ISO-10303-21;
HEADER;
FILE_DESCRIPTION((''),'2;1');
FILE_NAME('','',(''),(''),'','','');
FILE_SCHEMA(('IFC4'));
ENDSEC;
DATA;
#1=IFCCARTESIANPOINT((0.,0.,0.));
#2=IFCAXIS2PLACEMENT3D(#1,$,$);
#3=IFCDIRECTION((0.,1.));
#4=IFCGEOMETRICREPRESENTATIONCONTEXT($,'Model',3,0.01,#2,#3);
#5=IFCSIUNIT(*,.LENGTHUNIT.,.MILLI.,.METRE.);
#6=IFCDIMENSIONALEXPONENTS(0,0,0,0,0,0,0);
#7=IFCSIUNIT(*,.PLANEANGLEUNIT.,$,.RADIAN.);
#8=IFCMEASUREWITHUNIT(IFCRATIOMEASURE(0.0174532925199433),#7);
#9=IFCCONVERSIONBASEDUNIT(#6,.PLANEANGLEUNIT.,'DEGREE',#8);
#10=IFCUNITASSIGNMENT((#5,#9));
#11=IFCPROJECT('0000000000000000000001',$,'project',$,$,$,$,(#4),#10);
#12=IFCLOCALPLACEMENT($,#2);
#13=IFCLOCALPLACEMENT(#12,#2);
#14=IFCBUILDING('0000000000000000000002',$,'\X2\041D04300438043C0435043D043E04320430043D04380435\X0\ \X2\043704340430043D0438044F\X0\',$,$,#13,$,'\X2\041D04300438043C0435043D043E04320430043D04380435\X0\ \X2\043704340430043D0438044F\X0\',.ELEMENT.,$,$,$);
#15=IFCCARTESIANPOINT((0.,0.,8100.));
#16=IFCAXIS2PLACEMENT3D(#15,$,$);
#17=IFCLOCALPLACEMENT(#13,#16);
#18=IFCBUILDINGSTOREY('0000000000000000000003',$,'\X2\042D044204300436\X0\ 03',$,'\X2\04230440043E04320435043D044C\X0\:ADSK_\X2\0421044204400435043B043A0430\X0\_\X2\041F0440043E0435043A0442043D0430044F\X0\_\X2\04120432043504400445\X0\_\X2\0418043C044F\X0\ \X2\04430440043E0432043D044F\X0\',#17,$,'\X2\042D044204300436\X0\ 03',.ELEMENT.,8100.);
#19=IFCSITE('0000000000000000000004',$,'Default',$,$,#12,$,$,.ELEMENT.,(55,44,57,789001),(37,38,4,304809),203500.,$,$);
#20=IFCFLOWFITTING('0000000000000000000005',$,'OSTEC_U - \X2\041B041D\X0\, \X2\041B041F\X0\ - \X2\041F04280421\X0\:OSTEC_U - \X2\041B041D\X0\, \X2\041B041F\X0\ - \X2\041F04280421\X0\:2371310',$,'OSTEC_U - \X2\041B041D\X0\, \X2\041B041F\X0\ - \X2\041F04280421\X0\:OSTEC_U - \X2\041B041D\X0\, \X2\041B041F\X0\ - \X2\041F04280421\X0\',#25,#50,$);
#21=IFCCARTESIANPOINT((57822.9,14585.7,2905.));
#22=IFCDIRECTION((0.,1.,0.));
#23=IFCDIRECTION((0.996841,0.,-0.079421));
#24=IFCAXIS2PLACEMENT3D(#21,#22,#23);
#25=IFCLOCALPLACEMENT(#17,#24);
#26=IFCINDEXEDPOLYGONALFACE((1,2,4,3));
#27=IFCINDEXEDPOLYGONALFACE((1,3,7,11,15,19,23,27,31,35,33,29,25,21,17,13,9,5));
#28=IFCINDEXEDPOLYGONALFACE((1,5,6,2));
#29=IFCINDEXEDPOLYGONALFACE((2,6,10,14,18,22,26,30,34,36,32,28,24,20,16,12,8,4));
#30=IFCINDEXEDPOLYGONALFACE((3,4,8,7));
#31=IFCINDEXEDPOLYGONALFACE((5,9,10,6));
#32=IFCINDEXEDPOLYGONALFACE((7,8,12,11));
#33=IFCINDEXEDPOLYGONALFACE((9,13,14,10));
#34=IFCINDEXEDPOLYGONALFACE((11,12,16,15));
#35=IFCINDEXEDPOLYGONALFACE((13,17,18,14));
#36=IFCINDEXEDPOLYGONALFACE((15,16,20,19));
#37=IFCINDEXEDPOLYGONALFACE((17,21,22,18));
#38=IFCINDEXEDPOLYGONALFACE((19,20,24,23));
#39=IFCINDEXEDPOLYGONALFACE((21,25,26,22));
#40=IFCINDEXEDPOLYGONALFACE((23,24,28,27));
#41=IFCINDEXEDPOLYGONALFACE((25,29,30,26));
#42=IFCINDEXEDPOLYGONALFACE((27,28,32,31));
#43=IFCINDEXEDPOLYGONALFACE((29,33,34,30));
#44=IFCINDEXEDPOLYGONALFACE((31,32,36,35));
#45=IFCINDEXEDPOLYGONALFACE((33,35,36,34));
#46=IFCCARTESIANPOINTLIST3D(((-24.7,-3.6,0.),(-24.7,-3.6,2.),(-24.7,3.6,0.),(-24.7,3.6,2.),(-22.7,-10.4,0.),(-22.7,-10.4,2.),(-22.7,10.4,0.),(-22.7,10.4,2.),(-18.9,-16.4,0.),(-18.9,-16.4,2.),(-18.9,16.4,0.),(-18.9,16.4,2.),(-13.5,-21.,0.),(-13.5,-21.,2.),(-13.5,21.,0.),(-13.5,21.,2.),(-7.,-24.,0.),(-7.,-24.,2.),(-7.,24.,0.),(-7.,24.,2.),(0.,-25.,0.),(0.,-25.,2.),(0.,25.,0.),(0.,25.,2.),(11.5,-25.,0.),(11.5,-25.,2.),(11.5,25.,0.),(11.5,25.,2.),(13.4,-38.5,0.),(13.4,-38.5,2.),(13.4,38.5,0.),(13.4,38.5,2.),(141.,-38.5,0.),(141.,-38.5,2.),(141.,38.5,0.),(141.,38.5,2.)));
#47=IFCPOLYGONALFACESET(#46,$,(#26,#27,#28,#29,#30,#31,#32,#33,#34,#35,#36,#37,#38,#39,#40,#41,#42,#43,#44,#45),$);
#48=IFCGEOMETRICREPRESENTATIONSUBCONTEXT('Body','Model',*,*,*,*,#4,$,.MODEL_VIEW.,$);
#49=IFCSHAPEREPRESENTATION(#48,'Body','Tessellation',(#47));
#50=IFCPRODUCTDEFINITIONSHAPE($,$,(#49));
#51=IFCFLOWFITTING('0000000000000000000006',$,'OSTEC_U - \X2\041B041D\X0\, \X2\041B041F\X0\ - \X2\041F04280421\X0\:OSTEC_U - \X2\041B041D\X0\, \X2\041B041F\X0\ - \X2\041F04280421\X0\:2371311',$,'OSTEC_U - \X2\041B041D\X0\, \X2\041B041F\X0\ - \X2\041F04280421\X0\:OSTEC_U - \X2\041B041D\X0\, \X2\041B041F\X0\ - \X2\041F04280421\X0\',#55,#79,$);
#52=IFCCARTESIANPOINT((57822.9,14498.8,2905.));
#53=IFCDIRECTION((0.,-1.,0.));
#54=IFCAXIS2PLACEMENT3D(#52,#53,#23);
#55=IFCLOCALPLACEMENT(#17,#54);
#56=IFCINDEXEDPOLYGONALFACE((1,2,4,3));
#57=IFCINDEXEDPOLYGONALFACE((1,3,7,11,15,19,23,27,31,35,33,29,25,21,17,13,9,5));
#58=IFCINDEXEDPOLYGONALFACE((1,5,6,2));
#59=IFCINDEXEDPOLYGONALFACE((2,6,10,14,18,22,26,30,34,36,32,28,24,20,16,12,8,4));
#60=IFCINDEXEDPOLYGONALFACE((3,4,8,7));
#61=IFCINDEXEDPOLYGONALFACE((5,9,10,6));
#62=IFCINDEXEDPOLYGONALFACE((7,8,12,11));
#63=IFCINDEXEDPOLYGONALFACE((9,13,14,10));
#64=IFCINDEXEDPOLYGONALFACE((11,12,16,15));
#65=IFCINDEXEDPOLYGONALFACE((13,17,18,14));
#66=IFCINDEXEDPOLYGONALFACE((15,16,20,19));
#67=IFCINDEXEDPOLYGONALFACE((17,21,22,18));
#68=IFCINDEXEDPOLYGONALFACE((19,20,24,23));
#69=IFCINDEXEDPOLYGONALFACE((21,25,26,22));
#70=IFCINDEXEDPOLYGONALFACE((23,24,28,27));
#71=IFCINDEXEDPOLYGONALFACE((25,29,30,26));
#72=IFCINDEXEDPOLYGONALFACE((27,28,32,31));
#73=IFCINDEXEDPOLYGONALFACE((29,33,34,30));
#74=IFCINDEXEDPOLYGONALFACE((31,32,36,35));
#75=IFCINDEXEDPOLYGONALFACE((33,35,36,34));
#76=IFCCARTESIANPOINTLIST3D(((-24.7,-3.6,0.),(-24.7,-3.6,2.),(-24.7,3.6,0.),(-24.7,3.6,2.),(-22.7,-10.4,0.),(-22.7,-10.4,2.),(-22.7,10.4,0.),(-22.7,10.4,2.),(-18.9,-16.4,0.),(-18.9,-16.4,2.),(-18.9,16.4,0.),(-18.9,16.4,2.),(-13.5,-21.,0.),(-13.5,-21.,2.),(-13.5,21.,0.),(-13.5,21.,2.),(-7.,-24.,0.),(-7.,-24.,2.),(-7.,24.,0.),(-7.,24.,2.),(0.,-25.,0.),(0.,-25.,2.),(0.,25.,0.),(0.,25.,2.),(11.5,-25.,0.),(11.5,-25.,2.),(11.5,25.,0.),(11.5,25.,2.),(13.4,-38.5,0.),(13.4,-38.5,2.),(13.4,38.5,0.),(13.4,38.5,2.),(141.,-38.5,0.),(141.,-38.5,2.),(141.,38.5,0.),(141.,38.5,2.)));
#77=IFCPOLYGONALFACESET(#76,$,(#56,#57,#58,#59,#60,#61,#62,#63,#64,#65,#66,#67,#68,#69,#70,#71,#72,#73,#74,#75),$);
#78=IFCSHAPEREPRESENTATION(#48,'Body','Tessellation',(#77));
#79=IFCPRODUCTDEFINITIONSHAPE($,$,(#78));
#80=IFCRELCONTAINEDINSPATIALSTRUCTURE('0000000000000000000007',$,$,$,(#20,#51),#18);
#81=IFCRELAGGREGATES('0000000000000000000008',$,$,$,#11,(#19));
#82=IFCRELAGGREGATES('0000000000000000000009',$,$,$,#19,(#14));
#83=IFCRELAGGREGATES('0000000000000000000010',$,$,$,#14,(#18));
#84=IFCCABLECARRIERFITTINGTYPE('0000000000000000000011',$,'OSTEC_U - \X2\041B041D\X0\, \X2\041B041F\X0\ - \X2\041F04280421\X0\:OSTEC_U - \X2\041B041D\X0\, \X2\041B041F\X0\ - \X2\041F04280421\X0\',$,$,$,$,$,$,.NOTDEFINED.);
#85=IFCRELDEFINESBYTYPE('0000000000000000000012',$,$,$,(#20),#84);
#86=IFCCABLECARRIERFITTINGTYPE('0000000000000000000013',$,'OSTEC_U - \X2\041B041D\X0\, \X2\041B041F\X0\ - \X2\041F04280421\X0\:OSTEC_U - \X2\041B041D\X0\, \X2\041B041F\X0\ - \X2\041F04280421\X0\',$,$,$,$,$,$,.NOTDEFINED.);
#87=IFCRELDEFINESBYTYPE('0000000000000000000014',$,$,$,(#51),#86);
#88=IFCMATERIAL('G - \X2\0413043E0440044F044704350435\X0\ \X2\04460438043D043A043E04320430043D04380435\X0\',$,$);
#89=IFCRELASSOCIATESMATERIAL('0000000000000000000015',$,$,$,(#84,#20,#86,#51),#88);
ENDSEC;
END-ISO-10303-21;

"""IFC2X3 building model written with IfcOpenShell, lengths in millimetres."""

from ifc_helpers import new_model, entity, si_unit, converted_unit, direction, frame, frame_2d, origin, place, context, subcontext, project, spatial, polyline, circle_curve, parameter, trimmed, segment, composite_curve, outline, extrude, source, transform, mapped, material, type_object, type_shapes, element, save


model = new_model("IFC2X3")

# Units and contexts
model_context = context("Model", 3, precision=0.01, world=origin(), true_north=direction((0.0, 1.0)))
body_context = subcontext(model_context, "Body", "Model", "MODEL_VIEW")
ifc_project = project(units=[si_unit("LENGTHUNIT", "METRE", prefix="MILLI"), converted_unit("PLANEANGLEUNIT", "DEGREE", entity("IfcRatioMeasure", 0.0174532925199433), si_unit("PLANEANGLEUNIT", "RADIAN"), dimensions=[0, 0, 0, 0, 0, 0, 0])], contexts=[model_context])

# Site, building, storey
site_placement = place(None, frame((0.0, 0.0, 0.0)))
site = spatial("IfcSite", under=ifc_project, at=site_placement, Name="Default", CompositionType="ELEMENT", RefLatitude=(55, 44, 57, 789001), RefLongitude=(37, 38, 4, 304809), RefElevation=203500.0)
building_placement = place(site_placement, origin())
building = spatial("IfcBuilding", under=site, at=building_placement, Name="Наименование здания", LongName="Наименование здания", CompositionType="ELEMENT")
storey_placement = place(building_placement, frame((0.0, 0.0, 8100.0)))
storey = spatial("IfcBuildingStorey", under=building, at=storey_placement, Name="Этаж 03", ObjectType="Уровень:ADSK_Стрелка_Проектная_Вверх_Имя уровня", LongName="Этаж 03", CompositionType="ELEMENT", Elevation=8100.0)

# Flow fittings
ifc_material = material(Name="G - Горячее цинкование")
cable_carrier_fitting_type_1 = type_object("IfcCableCarrierFittingType", Name="OSTEC_U - ЛН, ЛП - ПШС:OSTEC_U - ЛН, ЛП - ПШС", PredefinedType="NOTDEFINED", material=ifc_material)
shared_shape_1 = source(origin(), body_context, "Body", "SweptSolid", [
    extrude(outline(composite_curve([segment(trimmed(circle_curve(frame_2d((-41.5, 0.0), x_axis=(1.0, 0.0)), 25.0), [parameter(90.0)], [parameter(270.0)], True, "PARAMETER"), True, "CONTINUOUS"), segment(polyline([(-41.5, -25.0), (-30.0, -25.0)]), True, "CONTINUOUS"), segment(polyline([(-30.0, -25.0), (-28.1, -38.5)]), True, "CONTINUOUS"), segment(polyline([(-28.1, -38.5), (99.5, -38.5)]), True, "CONTINUOUS"), segment(polyline([(99.5, -38.5), (99.5, 38.5)]), True, "CONTINUOUS"), segment(polyline([(99.5, 38.5), (-28.1, 38.5)]), True, "CONTINUOUS"), segment(polyline([(-28.1, 38.5), (-30.0, 25.0)]), True, "CONTINUOUS"), segment(polyline([(-30.0, 25.0), (-41.5, 25.0)]), True, "CONTINUOUS")], self_intersect=False)), frame((41.5, 0.0, 0.0), z_axis=(0.0, 0.0, -1.0), x_axis=(1.0, 0.0, 0.0)), (0.0, 0.0, -1.0), 2.0),
])
type_shapes(cable_carrier_fitting_type_1, [shared_shape_1])
for number, where, z_axis, x_axis, name in (
    (1, (57822.9, 14585.7, 2905.0), (0.0, 1.0, 0.0), (0.996841, 0.0, -0.079421), "OSTEC_U - ЛН, ЛП - ПШС:OSTEC_U - ЛН, ЛП - ПШС:2371310"),
):
    element("IfcFlowFitting", number, at=place(storey_placement, frame(where, z_axis=z_axis, x_axis=x_axis)), inside=storey, type_object=cable_carrier_fitting_type_1, material=ifc_material, Name=name, ObjectType="OSTEC_U - ЛН, ЛП - ПШС:OSTEC_U - ЛН, ЛП - ПШС", context=body_context, shape_type="MappedRepresentation", body=[
        mapped(shared_shape_1, transform((0.0, 0.0, 0.0), scale=1.0)),
    ])
cable_carrier_fitting_type_2 = type_object("IfcCableCarrierFittingType", Name="OSTEC_U - ЛН, ЛП - ПШС:OSTEC_U - ЛН, ЛП - ПШС", PredefinedType="NOTDEFINED", material=ifc_material)
shared_shape_2 = source(origin(), body_context, "Body", "SweptSolid", [
    extrude(outline(composite_curve([segment(trimmed(circle_curve(frame_2d((-41.5, 0.0), x_axis=(1.0, 0.0)), 25.0), [parameter(90.0)], [parameter(270.0)], True, "PARAMETER"), True, "CONTINUOUS"), segment(polyline([(-41.5, -25.0), (-30.0, -25.0)]), True, "CONTINUOUS"), segment(polyline([(-30.0, -25.0), (-28.1, -38.5)]), True, "CONTINUOUS"), segment(polyline([(-28.1, -38.5), (99.5, -38.5)]), True, "CONTINUOUS"), segment(polyline([(99.5, -38.5), (99.5, 38.5)]), True, "CONTINUOUS"), segment(polyline([(99.5, 38.5), (-28.1, 38.5)]), True, "CONTINUOUS"), segment(polyline([(-28.1, 38.5), (-30.0, 25.0)]), True, "CONTINUOUS"), segment(polyline([(-30.0, 25.0), (-41.5, 25.0)]), True, "CONTINUOUS")], self_intersect=False)), frame((41.5, 0.0, 0.0)), (0.0, 0.0, 1.0), 2.0),
])
type_shapes(cable_carrier_fitting_type_2, [shared_shape_2])
for number, where, z_axis, x_axis, name in (
    (2, (57822.9, 14498.8, 2905.0), (0.0, -1.0, 0.0), (0.996841, 0.0, -0.079421), "OSTEC_U - ЛН, ЛП - ПШС:OSTEC_U - ЛН, ЛП - ПШС:2371311"),
):
    element("IfcFlowFitting", number, at=place(storey_placement, frame(where, z_axis=z_axis, x_axis=x_axis)), inside=storey, type_object=cable_carrier_fitting_type_2, material=ifc_material, Name=name, ObjectType="OSTEC_U - ЛН, ЛП - ПШС:OSTEC_U - ЛН, ЛП - ПШС", context=body_context, shape_type="MappedRepresentation", body=[
        mapped(shared_shape_2, transform((0.0, 0.0, 0.0), scale=1.0)),
    ])

save(model, "model.ifc")
